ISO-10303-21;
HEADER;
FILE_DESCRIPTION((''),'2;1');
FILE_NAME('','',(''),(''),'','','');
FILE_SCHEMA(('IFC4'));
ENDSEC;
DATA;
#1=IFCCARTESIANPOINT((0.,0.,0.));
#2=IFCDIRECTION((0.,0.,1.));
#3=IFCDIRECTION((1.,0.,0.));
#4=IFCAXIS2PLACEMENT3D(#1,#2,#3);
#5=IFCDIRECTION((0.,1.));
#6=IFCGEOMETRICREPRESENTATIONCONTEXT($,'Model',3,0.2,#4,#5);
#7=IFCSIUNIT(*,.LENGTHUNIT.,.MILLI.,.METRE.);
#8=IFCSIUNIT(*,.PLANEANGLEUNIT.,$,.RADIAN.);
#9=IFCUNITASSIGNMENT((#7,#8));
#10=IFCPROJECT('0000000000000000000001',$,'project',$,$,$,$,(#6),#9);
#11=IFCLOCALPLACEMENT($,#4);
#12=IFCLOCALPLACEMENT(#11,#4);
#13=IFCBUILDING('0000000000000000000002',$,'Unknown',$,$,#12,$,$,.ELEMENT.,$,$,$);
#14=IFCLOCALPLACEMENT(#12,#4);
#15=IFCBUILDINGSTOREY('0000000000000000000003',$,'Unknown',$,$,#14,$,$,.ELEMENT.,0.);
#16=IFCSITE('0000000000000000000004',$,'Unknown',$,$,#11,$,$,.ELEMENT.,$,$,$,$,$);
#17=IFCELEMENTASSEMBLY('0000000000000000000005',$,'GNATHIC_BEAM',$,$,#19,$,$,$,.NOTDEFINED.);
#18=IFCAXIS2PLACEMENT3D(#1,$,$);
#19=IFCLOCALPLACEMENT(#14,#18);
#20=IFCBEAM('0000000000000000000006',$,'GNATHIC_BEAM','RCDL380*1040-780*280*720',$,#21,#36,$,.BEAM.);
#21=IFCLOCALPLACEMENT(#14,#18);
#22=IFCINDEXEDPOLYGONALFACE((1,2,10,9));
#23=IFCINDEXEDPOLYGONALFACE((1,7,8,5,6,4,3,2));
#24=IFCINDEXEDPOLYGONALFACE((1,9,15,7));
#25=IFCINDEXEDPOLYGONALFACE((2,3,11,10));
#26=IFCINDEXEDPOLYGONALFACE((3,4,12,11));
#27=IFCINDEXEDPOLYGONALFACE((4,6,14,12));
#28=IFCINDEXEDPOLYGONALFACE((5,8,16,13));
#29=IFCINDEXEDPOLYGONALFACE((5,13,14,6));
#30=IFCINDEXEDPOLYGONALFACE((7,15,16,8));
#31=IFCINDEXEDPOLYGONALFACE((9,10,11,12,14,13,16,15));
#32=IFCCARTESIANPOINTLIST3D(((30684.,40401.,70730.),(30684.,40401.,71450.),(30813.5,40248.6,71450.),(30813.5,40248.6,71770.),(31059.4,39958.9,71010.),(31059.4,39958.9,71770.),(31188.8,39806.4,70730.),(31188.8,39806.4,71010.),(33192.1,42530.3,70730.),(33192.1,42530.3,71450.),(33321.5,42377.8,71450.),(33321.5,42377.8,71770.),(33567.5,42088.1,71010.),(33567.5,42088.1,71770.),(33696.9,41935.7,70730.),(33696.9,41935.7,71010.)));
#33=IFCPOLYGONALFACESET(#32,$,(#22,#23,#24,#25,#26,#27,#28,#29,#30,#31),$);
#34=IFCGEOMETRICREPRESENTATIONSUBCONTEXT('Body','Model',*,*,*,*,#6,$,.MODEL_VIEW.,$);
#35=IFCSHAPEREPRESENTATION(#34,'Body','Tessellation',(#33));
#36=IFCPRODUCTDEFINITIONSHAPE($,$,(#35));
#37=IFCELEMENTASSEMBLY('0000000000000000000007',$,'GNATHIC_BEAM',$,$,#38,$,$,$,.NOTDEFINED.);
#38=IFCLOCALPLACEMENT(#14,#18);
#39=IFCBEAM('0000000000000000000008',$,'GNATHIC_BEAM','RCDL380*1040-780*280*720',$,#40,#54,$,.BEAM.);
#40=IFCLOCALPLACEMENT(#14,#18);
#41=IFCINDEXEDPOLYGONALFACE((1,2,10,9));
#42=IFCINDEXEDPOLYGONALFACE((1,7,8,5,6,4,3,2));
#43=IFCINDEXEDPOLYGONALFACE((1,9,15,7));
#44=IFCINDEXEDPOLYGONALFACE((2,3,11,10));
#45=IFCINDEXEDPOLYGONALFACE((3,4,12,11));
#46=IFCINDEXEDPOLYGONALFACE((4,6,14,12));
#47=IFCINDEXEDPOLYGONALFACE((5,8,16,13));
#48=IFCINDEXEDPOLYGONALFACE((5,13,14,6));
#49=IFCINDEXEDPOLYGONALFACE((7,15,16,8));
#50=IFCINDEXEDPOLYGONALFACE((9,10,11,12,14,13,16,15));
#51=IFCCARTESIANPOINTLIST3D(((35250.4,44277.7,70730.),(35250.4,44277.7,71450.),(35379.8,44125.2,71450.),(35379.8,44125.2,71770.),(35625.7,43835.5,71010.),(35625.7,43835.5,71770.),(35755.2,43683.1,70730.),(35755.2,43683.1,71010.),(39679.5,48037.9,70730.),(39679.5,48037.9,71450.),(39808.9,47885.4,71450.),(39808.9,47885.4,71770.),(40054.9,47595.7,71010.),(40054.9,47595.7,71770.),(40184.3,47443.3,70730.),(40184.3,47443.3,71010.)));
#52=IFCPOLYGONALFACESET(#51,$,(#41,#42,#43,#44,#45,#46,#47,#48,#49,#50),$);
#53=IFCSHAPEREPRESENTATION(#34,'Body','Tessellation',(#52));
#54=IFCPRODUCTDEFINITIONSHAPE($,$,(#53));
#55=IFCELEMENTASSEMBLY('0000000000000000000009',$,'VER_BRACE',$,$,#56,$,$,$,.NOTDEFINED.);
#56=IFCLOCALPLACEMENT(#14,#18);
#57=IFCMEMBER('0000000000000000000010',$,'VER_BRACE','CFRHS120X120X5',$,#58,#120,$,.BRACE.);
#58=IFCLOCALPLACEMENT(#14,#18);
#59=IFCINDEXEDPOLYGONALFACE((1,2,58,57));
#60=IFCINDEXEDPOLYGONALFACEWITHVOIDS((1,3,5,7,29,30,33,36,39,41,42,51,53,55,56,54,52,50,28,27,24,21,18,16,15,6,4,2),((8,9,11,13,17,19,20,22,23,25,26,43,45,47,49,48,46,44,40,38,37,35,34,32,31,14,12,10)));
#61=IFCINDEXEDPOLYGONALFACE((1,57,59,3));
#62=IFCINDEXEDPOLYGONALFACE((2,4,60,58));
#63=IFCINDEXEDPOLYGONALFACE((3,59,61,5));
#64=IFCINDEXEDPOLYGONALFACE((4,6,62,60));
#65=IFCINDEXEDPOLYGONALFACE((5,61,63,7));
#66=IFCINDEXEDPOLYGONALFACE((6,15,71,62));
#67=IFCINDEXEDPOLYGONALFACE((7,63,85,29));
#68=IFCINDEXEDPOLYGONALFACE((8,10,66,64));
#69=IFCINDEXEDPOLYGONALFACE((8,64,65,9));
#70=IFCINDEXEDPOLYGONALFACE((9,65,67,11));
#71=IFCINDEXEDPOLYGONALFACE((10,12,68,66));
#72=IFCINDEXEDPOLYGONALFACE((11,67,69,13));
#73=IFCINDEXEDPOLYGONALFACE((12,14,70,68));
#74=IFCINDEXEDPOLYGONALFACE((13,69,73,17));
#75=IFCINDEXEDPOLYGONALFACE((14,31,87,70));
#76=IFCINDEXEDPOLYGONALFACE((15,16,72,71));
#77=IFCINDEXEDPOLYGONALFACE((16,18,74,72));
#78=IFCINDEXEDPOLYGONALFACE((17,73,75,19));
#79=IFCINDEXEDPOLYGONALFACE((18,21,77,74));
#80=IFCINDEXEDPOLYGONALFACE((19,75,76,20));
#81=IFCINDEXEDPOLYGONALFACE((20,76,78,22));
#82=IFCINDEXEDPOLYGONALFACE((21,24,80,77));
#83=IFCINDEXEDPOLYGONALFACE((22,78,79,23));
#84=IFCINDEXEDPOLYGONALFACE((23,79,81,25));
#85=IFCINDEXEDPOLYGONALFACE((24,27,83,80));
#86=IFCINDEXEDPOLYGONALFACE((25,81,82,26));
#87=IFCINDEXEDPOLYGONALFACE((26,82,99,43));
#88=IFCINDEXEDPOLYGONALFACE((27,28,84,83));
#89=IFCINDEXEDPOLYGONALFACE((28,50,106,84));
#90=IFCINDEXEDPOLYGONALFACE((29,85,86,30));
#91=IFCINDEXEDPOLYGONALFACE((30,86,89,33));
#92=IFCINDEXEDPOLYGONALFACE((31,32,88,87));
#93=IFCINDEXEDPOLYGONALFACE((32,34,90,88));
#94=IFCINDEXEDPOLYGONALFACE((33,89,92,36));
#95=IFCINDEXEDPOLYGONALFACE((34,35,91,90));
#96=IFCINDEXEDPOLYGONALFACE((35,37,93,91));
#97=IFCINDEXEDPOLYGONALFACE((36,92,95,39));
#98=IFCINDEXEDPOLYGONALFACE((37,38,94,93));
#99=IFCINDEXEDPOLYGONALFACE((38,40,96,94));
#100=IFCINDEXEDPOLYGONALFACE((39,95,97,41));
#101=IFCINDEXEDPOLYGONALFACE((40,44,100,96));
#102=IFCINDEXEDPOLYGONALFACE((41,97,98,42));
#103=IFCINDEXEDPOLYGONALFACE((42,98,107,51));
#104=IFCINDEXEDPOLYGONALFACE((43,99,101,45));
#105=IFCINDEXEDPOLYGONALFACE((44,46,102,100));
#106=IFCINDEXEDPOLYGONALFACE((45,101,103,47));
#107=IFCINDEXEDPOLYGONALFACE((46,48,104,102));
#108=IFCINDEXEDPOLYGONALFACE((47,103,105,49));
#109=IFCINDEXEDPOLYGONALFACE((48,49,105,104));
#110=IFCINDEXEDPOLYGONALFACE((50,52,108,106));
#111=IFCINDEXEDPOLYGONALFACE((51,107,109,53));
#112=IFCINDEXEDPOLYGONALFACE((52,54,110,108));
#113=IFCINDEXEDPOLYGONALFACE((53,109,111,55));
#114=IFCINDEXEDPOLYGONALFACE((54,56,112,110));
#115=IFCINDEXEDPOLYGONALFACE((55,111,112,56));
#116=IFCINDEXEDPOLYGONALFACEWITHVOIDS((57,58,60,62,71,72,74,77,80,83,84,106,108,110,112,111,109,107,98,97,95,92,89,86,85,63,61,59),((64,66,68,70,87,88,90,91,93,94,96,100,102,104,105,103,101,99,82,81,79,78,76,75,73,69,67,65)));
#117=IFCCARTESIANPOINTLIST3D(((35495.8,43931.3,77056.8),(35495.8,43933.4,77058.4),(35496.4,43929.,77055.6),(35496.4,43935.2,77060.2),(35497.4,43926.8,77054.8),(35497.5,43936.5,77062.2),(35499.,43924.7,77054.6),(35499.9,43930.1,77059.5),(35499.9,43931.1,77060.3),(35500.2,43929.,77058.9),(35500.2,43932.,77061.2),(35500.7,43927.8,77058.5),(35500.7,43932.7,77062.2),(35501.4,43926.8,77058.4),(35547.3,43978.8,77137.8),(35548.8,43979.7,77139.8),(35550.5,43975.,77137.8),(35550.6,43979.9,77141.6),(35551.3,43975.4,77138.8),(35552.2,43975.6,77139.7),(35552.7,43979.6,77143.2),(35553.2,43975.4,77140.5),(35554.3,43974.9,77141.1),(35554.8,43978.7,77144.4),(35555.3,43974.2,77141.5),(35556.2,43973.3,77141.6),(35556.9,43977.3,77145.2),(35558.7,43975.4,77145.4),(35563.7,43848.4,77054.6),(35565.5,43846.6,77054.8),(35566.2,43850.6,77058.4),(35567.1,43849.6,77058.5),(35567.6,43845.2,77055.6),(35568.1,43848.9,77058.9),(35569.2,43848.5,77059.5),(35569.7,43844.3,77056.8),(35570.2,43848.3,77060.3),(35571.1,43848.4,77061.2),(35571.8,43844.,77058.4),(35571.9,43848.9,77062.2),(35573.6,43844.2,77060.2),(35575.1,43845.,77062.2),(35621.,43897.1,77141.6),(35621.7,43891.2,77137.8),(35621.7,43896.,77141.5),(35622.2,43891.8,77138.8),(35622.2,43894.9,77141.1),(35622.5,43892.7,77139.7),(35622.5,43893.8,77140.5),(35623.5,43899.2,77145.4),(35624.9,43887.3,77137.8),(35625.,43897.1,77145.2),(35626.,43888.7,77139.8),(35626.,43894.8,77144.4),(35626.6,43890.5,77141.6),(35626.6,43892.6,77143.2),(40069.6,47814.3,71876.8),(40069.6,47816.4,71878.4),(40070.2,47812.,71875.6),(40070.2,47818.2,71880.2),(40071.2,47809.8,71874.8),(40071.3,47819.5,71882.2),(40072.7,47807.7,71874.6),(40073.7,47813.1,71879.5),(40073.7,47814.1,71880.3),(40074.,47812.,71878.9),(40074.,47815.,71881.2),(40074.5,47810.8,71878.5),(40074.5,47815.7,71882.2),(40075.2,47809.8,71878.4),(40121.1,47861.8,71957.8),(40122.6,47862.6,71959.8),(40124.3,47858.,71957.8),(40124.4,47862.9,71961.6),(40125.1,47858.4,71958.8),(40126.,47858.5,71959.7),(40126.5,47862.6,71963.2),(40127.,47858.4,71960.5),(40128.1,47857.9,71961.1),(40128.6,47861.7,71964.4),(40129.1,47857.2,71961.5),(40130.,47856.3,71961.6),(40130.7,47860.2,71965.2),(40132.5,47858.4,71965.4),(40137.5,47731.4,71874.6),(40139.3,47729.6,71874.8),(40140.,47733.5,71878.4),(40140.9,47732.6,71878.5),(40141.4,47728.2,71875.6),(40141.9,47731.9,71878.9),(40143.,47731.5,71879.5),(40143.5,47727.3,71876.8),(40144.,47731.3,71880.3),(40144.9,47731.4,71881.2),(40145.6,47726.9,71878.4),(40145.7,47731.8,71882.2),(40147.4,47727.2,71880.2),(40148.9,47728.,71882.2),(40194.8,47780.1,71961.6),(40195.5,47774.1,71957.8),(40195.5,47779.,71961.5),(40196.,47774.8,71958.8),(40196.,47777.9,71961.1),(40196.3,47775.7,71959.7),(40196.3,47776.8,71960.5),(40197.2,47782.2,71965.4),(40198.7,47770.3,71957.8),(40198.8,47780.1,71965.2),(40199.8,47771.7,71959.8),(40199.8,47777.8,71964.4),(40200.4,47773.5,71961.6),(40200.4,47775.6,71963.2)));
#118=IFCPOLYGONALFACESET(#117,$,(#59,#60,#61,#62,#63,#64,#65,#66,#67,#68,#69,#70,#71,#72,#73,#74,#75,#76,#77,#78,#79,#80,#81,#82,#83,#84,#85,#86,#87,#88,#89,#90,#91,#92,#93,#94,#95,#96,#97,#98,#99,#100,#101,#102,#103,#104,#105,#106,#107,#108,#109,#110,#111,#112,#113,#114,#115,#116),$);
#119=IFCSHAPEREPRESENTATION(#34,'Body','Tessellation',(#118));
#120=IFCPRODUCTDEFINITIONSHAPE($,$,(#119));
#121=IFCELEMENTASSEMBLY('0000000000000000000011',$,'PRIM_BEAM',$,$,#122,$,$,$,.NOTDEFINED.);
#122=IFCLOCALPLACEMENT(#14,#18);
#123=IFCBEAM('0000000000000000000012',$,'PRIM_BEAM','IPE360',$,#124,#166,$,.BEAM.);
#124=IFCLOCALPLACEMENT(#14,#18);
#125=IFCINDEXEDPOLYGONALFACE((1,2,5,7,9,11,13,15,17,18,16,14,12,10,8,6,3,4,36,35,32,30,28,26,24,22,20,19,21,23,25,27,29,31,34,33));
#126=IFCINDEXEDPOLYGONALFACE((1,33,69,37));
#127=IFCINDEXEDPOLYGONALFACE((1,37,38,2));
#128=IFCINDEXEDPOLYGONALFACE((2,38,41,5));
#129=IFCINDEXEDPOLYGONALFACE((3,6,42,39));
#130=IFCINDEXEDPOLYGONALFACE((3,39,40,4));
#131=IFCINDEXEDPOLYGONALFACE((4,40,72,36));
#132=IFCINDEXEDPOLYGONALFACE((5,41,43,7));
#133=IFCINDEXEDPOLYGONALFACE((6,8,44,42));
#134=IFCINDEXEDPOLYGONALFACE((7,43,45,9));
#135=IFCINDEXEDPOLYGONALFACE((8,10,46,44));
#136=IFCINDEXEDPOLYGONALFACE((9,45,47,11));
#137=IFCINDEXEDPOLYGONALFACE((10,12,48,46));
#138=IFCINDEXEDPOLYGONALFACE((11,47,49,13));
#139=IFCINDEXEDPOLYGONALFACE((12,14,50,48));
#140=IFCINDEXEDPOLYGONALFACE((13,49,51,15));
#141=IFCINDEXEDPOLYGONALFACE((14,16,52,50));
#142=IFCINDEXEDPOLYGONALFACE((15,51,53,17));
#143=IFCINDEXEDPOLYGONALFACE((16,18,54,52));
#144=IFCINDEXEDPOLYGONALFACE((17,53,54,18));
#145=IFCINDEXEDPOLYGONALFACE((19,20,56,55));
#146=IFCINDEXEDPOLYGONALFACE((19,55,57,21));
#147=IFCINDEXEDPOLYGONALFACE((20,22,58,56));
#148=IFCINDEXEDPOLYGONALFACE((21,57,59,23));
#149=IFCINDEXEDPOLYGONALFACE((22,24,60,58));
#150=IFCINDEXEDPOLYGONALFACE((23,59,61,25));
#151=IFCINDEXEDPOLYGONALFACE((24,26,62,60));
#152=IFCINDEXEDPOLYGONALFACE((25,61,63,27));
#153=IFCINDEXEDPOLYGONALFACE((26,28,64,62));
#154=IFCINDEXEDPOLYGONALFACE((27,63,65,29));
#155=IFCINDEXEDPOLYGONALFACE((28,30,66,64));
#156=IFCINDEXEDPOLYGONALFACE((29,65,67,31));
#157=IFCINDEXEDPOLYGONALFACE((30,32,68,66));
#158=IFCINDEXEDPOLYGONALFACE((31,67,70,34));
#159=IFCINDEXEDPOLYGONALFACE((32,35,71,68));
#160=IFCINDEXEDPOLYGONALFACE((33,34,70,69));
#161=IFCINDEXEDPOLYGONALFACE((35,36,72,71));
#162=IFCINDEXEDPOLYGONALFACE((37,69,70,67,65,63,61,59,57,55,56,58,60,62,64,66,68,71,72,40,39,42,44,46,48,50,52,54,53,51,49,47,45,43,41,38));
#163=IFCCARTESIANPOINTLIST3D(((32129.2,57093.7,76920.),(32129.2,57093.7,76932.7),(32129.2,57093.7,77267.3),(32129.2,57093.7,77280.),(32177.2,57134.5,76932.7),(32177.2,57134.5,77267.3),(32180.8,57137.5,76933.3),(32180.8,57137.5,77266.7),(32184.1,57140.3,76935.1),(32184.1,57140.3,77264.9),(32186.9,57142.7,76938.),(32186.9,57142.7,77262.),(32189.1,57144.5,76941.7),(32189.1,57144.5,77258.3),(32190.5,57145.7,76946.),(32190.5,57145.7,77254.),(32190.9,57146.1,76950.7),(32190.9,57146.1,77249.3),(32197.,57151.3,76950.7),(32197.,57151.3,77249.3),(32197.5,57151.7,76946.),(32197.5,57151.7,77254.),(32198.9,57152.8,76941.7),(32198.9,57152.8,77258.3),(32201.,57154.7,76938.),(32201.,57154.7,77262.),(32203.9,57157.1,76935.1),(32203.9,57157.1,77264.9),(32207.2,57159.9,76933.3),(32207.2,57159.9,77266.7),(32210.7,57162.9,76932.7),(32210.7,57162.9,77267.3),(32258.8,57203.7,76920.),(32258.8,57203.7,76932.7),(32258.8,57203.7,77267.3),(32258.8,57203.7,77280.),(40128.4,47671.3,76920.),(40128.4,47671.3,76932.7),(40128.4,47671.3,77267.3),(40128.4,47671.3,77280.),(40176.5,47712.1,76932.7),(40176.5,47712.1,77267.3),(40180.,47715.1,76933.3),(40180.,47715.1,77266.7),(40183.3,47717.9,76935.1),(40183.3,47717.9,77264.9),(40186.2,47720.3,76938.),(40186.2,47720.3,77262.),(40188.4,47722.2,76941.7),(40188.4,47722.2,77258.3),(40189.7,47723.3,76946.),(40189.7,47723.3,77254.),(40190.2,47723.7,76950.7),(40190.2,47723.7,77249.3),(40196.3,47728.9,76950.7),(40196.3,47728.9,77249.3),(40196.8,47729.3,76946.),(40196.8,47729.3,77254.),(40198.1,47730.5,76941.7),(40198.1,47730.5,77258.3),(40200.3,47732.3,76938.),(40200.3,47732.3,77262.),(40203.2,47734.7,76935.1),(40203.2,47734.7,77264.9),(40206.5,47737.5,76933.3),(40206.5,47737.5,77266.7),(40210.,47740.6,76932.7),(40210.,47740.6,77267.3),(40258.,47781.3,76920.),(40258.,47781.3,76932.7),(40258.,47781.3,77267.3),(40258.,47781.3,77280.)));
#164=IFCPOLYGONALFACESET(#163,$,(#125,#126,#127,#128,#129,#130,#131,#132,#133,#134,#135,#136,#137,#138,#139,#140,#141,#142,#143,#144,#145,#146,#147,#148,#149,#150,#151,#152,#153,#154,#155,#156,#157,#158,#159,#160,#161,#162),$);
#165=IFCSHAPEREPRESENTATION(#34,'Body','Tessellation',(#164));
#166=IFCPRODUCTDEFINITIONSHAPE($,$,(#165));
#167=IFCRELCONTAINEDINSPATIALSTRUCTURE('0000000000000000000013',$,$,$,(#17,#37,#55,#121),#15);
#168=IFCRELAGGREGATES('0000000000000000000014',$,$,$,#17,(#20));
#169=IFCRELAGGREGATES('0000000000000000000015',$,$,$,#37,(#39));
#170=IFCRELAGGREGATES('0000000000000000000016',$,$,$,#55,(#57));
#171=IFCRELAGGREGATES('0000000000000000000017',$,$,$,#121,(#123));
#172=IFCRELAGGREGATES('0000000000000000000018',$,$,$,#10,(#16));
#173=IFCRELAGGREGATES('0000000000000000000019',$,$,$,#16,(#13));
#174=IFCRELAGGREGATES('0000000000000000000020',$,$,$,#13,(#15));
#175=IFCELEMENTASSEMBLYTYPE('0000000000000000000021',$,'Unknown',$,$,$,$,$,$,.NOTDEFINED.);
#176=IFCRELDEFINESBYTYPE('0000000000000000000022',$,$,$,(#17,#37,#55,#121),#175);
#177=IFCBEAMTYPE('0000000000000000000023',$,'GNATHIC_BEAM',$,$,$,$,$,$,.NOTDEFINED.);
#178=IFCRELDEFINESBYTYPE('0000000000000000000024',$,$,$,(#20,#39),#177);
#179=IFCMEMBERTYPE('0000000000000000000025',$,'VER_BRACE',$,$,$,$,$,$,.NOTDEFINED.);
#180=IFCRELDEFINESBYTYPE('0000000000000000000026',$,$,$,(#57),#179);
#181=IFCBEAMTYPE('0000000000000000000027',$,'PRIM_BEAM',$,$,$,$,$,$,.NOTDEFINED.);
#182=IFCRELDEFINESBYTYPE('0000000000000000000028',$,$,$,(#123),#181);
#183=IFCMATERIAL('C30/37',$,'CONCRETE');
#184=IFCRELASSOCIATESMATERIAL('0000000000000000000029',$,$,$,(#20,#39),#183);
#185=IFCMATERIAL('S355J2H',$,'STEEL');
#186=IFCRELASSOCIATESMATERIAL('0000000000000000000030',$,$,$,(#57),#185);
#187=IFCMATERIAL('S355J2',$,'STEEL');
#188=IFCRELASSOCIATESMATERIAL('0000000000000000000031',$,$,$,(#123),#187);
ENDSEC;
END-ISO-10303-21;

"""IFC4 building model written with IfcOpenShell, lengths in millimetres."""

from ifc_helpers import new_model, si_unit, direction, frame, origin_with_axes, origin_2d_with_axis, place, context, subcontext, project, spatial, polyline, hollow_rectangle, i_section, outline, extrude, material, material_profile, profile_set, profile_usage, type_object, element, aggregate, save


model = new_model("IFC4")

# Units and contexts
model_context = context("Model", 3, precision=0.2, world=origin_with_axes(), true_north=direction((0.0, 1.0)))
body_context = subcontext(model_context, "Body", "Model", "MODEL_VIEW")
ifc_project = project(units=[si_unit("LENGTHUNIT", "METRE", prefix="MILLI"), si_unit("PLANEANGLEUNIT", "RADIAN")], contexts=[model_context])

# Site, building, storey
site_placement = place(None, origin_with_axes())
site = spatial("IfcSite", under=ifc_project, at=site_placement, Name="Unknown", CompositionType="ELEMENT")
building_placement = place(site_placement, origin_with_axes())
building = spatial("IfcBuilding", under=site, at=building_placement, Name="Unknown", CompositionType="ELEMENT")
storey_placement = place(building_placement, origin_with_axes())
storey = spatial("IfcBuildingStorey", under=building, at=storey_placement, Name="Unknown", CompositionType="ELEMENT", Elevation=0.0)

# Shared definitions
element_assembly_type = type_object("IfcElementAssemblyType", Name="Unknown", PredefinedType="NOTDEFINED")
ifc_material_1 = material(Name="S355J2", Category="STEEL")

# Element assemblies, beams
ifc_material_2 = material(Name="C30/37", Category="CONCRETE")
assembly_1_placement = place(storey_placement, frame((30936.4, 40103.7, 71250.0), z_axis=(0.64719, -0.762329, 0.0), x_axis=(0.762329, 0.64719, 0.0)))
assembly_1 = element("IfcElementAssembly", 1, at=assembly_1_placement, inside=storey, type_object=element_assembly_type, Name="GNATHIC_BEAM", PredefinedType="NOTDEFINED")
ifc_material_profile_1 = material_profile(ifc_material_2, outline(polyline([(-390.0, -520.0), (390.0, -520.0), (390.0, -240.0), (190.0, -240.0), (190.0, 520.0), (-190.0, 520.0), (-190.0, 200.0), (-390.0, 200.0), (-390.0, -520.0)])), Name="RCDL380*1040-780*280*720")
ifc_profile_set_1 = profile_set([ifc_material_profile_1])
ifc_profile_usage_1 = profile_usage(ifc_profile_set_1, cardinal=2)
beam_type_1 = type_object("IfcBeamType", Name="GNATHIC_BEAM")
beam_1_placement = place(assembly_1_placement, origin_with_axes())
beam_1 = element("IfcBeam", 2, at=beam_1_placement, type_object=beam_type_1, material=ifc_profile_usage_1, Name="GNATHIC_BEAM", Description="RCDL380*1040-780*280*720", PredefinedType="BEAM", context=body_context, shape_type="SolidModel", body=[
    extrude(outline(polyline([(-390.0, -520.0), (390.0, -520.0), (390.0, -240.0), (190.0, -240.0), (190.0, 520.0), (-190.0, 520.0), (-190.0, 200.0), (-390.0, 200.0), (-390.0, -520.0)])), frame((0.0, 0.0, 0.0), z_axis=(-1.0, 0.0, 0.0), x_axis=(0.0, 0.0, 1.0)), (0.0, 0.0, -1.0), 3290.0),
])
aggregate(assembly_1, [beam_1])
assembly_2_placement = place(storey_placement, frame((35502.8, 43980.4, 71250.0), z_axis=(0.64719, -0.762329, 0.0), x_axis=(0.762329, 0.64719, 0.0)))
assembly_2 = element("IfcElementAssembly", 3, at=assembly_2_placement, inside=storey, type_object=element_assembly_type, Name="GNATHIC_BEAM", PredefinedType="NOTDEFINED")
beam_2_placement = place(assembly_2_placement, origin_with_axes())
beam_2 = element("IfcBeam", 4, at=beam_2_placement, type_object=beam_type_1, material=ifc_profile_usage_1, Name="GNATHIC_BEAM", Description="RCDL380*1040-780*280*720", PredefinedType="BEAM", context=body_context, shape_type="SolidModel", body=[
    extrude(outline(polyline([(-390.0, -520.0), (390.0, -520.0), (390.0, -240.0), (190.0, -240.0), (190.0, 520.0), (-190.0, 520.0), (-190.0, 200.0), (-390.0, 200.0), (-390.0, -520.0)])), frame((0.0, 0.0, 0.0), z_axis=(-1.0, 0.0, 0.0), x_axis=(0.0, 0.0, 1.0)), (0.0, 0.0, -1.0), 5810.0),
])
aggregate(assembly_2, [beam_2])

# Element assembly, member
assembly_3_placement = place(storey_placement, frame((35561.2, 43911.9, 77100.0), z_axis=(0.64719, -0.762329, 0.0), x_axis=(0.577025, 0.489874, -0.653503)))
assembly_3 = element("IfcElementAssembly", 5, at=assembly_3_placement, inside=storey, type_object=element_assembly_type, Name="VER_BRACE", PredefinedType="NOTDEFINED")
ifc_material_3 = material(Name="S355J2H", Category="STEEL")
ifc_material_profile_2 = material_profile(ifc_material_3, hollow_rectangle(XDim=120.0, YDim=120.0, WallThickness=5.0, InnerFilletRadius=5.0, OuterFilletRadius=10.0, at=origin_2d_with_axis()), Name="CFRHS120X120X5")
ifc_profile_set_2 = profile_set([ifc_material_profile_2])
ifc_profile_usage_2 = profile_usage(ifc_profile_set_2, cardinal=5)
member_type = type_object("IfcMemberType", Name="VER_BRACE")
member_placement = place(assembly_3_placement, origin_with_axes())
member = element("IfcMember", 6, at=member_placement, type_object=member_type, material=ifc_profile_usage_2, Name="VER_BRACE", Description="CFRHS120X120X5", PredefinedType="BRACE", context=body_context, shape_type="SolidModel", body=[
    extrude(hollow_rectangle(XDim=120.0, YDim=120.0, WallThickness=5.0, InnerFilletRadius=5.0, OuterFilletRadius=10.0, at=origin_2d_with_axis()), frame((0.0, 0.0, 0.0), z_axis=(-1.0, 0.0, 0.0), x_axis=(0.0, 0.0, 1.0)), (0.0, 0.0, -1.0), 7926.5),
])
aggregate(assembly_3, [member])

# Element assembly, beam
assembly_4_placement = place(storey_placement, frame((40193.2, 47726.3, 77100.0), z_axis=(0.762329, 0.64719, 0.0), x_axis=(-0.64719, 0.762329, 0.0)))
assembly_4 = element("IfcElementAssembly", 7, at=assembly_4_placement, inside=storey, type_object=element_assembly_type, Name="PRIM_BEAM", PredefinedType="NOTDEFINED")
ifc_material_profile_3 = material_profile(ifc_material_1, i_section(OverallWidth=170.0, OverallDepth=360.0, WebThickness=8.0, FlangeThickness=12.7, FilletRadius=18.0, FlangeEdgeRadius=0.0, FlangeSlope=0.0, at=origin_2d_with_axis()), Name="IPE360")
ifc_profile_set_3 = profile_set([ifc_material_profile_3])
ifc_profile_usage_3 = profile_usage(ifc_profile_set_3, cardinal=2)
beam_type_2 = type_object("IfcBeamType", Name="PRIM_BEAM")
beam_3_placement = place(assembly_4_placement, origin_with_axes())
beam_3 = element("IfcBeam", 8, at=beam_3_placement, type_object=beam_type_2, material=ifc_profile_usage_3, Name="PRIM_BEAM", Description="IPE360", PredefinedType="BEAM", context=body_context, shape_type="SolidModel", body=[
    extrude(i_section(OverallWidth=170.0, OverallDepth=360.0, WebThickness=8.0, FlangeThickness=12.7, FilletRadius=18.0, FlangeEdgeRadius=0.0, FlangeSlope=0.0, at=origin_2d_with_axis()), frame((0.0, 0.0, 0.0), z_axis=(-1.0, 0.0, 0.0), x_axis=(0.0, 0.0, 1.0)), (0.0, 0.0, -1.0), 12360.0),
])
aggregate(assembly_4, [beam_3])

save(model, "model.ifc")
